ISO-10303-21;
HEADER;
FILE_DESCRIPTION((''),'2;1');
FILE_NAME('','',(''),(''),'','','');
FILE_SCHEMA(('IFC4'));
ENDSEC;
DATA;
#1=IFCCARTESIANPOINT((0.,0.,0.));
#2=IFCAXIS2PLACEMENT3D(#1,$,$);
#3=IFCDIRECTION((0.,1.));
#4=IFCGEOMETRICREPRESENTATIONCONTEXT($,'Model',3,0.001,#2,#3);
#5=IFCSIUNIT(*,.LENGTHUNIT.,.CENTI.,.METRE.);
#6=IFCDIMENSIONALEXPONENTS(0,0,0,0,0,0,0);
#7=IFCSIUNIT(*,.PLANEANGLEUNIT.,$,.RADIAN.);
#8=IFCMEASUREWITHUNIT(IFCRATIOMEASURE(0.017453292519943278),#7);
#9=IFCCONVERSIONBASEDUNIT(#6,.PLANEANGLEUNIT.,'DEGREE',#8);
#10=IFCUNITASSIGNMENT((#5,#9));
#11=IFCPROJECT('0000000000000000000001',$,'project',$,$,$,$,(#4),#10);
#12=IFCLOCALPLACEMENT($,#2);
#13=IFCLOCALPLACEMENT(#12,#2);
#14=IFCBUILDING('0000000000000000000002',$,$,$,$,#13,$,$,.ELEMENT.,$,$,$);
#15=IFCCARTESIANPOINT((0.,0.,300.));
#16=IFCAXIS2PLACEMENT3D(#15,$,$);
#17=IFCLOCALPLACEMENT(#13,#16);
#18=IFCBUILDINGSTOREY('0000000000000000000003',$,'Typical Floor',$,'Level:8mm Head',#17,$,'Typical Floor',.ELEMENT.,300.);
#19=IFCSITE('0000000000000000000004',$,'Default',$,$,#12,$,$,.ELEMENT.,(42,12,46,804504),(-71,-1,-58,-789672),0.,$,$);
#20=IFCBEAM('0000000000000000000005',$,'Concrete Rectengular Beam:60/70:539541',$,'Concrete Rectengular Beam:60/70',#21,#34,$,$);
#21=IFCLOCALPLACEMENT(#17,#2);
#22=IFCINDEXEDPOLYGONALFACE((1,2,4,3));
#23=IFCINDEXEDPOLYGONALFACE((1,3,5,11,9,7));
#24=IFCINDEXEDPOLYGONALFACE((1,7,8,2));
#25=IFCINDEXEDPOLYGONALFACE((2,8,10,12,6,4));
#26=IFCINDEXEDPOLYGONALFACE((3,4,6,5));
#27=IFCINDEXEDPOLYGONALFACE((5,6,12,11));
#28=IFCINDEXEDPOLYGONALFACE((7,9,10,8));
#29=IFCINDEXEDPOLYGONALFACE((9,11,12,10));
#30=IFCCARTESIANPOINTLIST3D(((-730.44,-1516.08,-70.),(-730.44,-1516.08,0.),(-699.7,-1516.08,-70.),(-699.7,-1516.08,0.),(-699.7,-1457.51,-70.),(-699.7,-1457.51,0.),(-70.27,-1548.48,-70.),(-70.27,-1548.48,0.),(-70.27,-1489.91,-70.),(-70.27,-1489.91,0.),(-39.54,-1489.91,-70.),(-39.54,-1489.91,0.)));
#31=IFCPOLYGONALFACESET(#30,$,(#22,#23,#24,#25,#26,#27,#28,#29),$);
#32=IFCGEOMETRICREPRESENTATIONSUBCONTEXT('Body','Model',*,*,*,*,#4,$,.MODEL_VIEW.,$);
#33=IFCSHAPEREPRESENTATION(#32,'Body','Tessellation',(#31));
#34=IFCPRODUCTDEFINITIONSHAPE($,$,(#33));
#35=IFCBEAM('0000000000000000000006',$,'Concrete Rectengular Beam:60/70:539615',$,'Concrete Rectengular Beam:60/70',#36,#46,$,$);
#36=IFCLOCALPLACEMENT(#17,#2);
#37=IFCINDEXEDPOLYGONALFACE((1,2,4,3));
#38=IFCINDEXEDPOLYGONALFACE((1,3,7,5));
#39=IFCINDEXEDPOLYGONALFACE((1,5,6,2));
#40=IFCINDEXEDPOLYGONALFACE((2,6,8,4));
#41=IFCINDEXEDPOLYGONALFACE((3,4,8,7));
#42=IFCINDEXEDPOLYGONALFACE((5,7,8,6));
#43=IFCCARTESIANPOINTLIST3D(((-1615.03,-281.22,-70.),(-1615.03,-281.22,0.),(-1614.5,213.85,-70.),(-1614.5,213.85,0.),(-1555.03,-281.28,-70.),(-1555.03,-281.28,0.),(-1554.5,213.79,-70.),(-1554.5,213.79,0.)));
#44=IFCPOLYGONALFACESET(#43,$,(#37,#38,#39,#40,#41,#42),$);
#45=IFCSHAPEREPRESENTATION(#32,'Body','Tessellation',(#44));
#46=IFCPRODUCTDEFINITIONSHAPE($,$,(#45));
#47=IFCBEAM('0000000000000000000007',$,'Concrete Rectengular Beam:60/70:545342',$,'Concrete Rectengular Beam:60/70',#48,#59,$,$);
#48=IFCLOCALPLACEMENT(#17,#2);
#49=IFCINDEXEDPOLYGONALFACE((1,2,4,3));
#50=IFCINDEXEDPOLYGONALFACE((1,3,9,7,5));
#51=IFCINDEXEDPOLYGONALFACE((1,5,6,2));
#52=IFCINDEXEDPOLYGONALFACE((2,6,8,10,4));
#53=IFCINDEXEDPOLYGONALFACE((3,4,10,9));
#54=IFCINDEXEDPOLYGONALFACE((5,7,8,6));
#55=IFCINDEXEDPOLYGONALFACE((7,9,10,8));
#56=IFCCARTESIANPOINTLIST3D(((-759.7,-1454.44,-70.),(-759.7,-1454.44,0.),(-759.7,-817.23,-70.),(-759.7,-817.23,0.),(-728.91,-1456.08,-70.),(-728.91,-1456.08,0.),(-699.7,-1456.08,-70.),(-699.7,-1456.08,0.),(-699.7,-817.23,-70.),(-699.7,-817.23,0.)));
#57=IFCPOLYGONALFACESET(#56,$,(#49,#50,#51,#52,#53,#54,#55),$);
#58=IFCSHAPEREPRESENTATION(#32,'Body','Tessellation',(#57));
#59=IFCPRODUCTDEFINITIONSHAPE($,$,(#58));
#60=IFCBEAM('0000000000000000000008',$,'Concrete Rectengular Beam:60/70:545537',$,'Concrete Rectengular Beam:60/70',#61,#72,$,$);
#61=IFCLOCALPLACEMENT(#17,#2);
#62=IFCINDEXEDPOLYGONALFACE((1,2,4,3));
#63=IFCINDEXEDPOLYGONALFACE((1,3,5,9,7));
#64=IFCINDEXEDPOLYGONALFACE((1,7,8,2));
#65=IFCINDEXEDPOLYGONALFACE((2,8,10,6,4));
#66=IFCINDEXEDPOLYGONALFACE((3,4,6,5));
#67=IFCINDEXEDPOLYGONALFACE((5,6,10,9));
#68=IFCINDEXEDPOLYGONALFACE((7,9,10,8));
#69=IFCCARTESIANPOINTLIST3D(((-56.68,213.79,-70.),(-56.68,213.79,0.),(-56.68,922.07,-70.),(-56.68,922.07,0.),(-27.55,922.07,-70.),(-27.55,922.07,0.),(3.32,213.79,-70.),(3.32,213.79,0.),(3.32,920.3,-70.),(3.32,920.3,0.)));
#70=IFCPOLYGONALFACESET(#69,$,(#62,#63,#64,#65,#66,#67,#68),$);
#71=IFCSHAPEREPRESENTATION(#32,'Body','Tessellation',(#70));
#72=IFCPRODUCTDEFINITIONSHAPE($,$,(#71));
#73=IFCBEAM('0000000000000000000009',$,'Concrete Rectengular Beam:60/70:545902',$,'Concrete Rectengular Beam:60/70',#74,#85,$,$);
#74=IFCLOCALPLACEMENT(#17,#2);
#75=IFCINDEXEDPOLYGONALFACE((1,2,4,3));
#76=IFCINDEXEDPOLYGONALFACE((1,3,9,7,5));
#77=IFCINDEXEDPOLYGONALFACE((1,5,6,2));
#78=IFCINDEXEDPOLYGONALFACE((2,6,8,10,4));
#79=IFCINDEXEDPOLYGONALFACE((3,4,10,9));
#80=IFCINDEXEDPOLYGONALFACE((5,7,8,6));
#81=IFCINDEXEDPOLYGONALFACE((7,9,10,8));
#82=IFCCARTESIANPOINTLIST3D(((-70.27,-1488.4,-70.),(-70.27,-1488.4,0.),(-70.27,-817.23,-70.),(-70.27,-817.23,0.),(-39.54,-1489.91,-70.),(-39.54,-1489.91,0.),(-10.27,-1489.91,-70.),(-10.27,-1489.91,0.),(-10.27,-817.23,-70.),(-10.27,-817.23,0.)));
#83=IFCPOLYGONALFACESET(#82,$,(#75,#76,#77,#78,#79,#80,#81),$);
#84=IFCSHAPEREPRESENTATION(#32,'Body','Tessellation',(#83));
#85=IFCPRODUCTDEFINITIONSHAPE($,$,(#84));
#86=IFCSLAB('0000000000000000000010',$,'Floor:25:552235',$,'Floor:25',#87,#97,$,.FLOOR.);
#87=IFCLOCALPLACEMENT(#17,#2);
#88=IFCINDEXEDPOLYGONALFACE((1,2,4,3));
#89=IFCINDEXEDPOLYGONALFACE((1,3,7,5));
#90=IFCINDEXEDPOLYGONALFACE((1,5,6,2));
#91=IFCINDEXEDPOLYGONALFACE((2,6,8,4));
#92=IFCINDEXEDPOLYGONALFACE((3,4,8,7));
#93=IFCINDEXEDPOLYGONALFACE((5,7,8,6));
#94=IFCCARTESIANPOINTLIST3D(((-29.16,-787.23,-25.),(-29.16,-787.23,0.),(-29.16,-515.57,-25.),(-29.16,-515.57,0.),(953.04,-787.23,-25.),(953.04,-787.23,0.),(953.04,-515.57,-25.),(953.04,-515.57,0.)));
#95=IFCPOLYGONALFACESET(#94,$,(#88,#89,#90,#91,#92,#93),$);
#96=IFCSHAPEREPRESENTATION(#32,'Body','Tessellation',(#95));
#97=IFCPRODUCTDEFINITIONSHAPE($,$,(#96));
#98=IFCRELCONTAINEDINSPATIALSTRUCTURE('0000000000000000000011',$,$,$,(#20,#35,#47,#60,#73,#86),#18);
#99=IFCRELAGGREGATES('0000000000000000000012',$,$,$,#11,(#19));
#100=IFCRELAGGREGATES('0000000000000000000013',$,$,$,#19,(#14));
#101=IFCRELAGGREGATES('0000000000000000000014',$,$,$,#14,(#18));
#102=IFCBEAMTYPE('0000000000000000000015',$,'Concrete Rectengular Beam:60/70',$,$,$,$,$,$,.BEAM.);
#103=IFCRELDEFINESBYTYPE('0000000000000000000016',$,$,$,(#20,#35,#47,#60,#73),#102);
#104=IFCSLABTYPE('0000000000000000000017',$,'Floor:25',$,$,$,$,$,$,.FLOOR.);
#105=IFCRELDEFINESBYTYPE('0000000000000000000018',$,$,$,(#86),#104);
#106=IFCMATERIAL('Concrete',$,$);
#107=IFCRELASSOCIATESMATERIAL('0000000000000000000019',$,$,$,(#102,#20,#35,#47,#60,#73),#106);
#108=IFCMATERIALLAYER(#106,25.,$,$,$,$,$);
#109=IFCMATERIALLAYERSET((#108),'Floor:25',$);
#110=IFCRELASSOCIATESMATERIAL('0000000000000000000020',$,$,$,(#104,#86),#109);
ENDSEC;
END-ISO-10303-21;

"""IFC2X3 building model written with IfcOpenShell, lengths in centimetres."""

from ifc_helpers import new_model, entity, si_unit, converted_unit, direction, frame, frame_2d, origin, place, context, subcontext, project, spatial, polyline, rectangle, extrude, clip, halfspace, bounded_halfspace, material, layer, layer_set, layer_usage, type_object, element, save


model = new_model("IFC2X3")

# Units and contexts
model_context = context("Model", 3, precision=0.001, world=origin(), true_north=direction((0.0, 1.0)))
body_context = subcontext(model_context, "Body", "Model", "MODEL_VIEW")
ifc_project = project(units=[si_unit("LENGTHUNIT", "METRE", prefix="CENTI"), converted_unit("PLANEANGLEUNIT", "DEGREE", entity("IfcRatioMeasure", 0.017453292519943278), si_unit("PLANEANGLEUNIT", "RADIAN"), dimensions=[0, 0, 0, 0, 0, 0, 0])], contexts=[model_context])

# Site, building, storey
site_placement = place(None, origin())
site = spatial("IfcSite", under=ifc_project, at=site_placement, Name="Default", CompositionType="ELEMENT", RefLatitude=(42, 12, 46, 804504), RefLongitude=(-71, -1, -58, -789672), RefElevation=0.0)
building_placement = place(site_placement, origin())
building = spatial("IfcBuilding", under=site, at=building_placement, CompositionType="ELEMENT")
storey_placement = place(building_placement, frame((0.0, 0.0, 300.0)))
storey = spatial("IfcBuildingStorey", under=building, at=storey_placement, Name="Typical Floor", ObjectType="Level:8mm Head", LongName="Typical Floor", CompositionType="ELEMENT", Elevation=300.0)

# Beams
ifc_material = material(Name="Concrete")
beam_type_1 = type_object("IfcBeamType", Name="Concrete Rectengular Beam:60/70", PredefinedType="BEAM", material=ifc_material)
beam_1_placement = place(storey_placement, frame((-40.27, -1519.91, 0.0), z_axis=(0.0, 0.0, 1.0), x_axis=(-0.998798, 0.049018, 0.0)))
element("IfcBeam", 1, at=beam_1_placement, inside=storey, type_object=beam_type_1, material=ifc_material, Name="Concrete Rectengular Beam:60/70:539541", ObjectType="Concrete Rectengular Beam:60/70", context=body_context, shape_type="SweptSolid", body=[
    clip(clip(clip(clip(extrude(rectangle(XDim=70.0, YDim=60.0, at=frame_2d((0.0, 0.0), x_axis=(1.0, 0.0))), frame((0.74, 0.0, -35.0), z_axis=(1.0, 0.0, 0.0), x_axis=(0.0, 0.0, -1.0)), (0.0, 0.0, 1.0), 688.79), bounded_halfspace(frame((658.83, 28.49, 0.0), z_axis=(0.998798, 0.049018, 0.0), x_axis=(0.0, 0.0, -1.0)), False, frame((0.74, 0.0, -35.0), z_axis=(1.0, 0.0, 0.0), x_axis=(0.0, 0.0, -1.0)), polyline([(35.0, 28.49), (-35.0, 28.49), (-35.0, -30.0), (-15.0, -30.0), (35.0, -30.0), (35.0, 28.49)]))), bounded_halfspace(frame((718.75, 31.43, 0.0), z_axis=(0.049018, -0.998798, 0.0), x_axis=(0.0, 0.0, -1.0)), False, frame((0.74, 0.0, -35.0), z_axis=(1.0, 0.0, 0.0), x_axis=(0.0, 0.0, -1.0)), polyline([(-35.0, 28.49), (35.0, 28.49), (35.0, 30.0), (-35.0, 30.0), (-35.0, 28.49)]))), bounded_halfspace(frame((-28.49, -31.43, 0.0), z_axis=(-0.049018, 0.998798, 0.0), x_axis=(0.0, 0.0, -1.0)), False, frame((0.74, 0.0, -35.0), z_axis=(1.0, 0.0, 0.0), x_axis=(0.0, 0.0, -1.0)), polyline([(-35.0, -28.49), (35.0, -28.49), (35.0, -30.0), (-35.0, -30.0), (-35.0, -28.49)]))), bounded_halfspace(frame((31.43, -28.49, 0.0), z_axis=(-0.998798, -0.049018, 0.0), x_axis=(0.0, 0.0, -1.0)), False, frame((0.74, 0.0, -35.0), z_axis=(1.0, 0.0, 0.0), x_axis=(0.0, 0.0, -1.0)), polyline([(35.0, -28.49), (-35.0, -28.49), (-35.0, 30.0), (35.0, 30.0), (35.0, -28.49)]))),
])
beam_2_placement = place(storey_placement, frame((-1585.07, -311.22, 0.0), z_axis=(0.0, 0.0, 1.0), x_axis=(0.001075, 0.999999, 0.0)))
element("IfcBeam", 2, at=beam_2_placement, inside=storey, type_object=beam_type_1, material=ifc_material, Name="Concrete Rectengular Beam:60/70:539615", ObjectType="Concrete Rectengular Beam:60/70", context=body_context, shape_type="SweptSolid", body=[
    extrude(rectangle(XDim=70.0, YDim=60.0, at=frame_2d((0.0, 0.0), x_axis=(1.0, 0.0))), frame((29.97, 0.0, -35.0), z_axis=(1.0, 0.0, 0.0), x_axis=(0.0, 0.0, -1.0)), (0.0, 0.0, 1.0), 495.07),
])
beam_3_placement = place(storey_placement, frame((-729.7, -1486.08, 0.0), z_axis=(0.0, 0.0, 1.0), x_axis=(0.0, 1.0, 0.0)))
element("IfcBeam", 3, at=beam_3_placement, inside=storey, type_object=beam_type_1, material=ifc_material, Name="Concrete Rectengular Beam:60/70:545342", ObjectType="Concrete Rectengular Beam:60/70", context=body_context, shape_type="SweptSolid", body=[
    clip(extrude(rectangle(XDim=70.0, YDim=60.0, at=frame_2d((0.0, 0.0), x_axis=(1.0, 0.0))), frame((30.0, 0.0, -35.0), z_axis=(1.0, 0.0, 0.0), x_axis=(0.0, 0.0, -1.0)), (0.0, 0.0, 1.0), 638.85), halfspace(frame((89.12, 1111.87, 0.0), z_axis=(-0.998591, 0.053061, 0.0), x_axis=(-0.053061, -0.998591, 0.0)), False)),
])
beam_4_placement = place(storey_placement, frame((-26.68, 952.07, 0.0), z_axis=(0.0, 0.0, 1.0), x_axis=(0.0, -1.0, 0.0)))
element("IfcBeam", 4, at=beam_4_placement, inside=storey, type_object=beam_type_1, material=ifc_material, Name="Concrete Rectengular Beam:60/70:545537", ObjectType="Concrete Rectengular Beam:60/70", context=body_context, shape_type="SweptSolid", body=[
    clip(extrude(rectangle(XDim=70.0, YDim=60.0, at=frame_2d((0.0, 0.0), x_axis=(1.0, 0.0))), frame((30.0, 0.0, -35.0), z_axis=(1.0, 0.0, 0.0), x_axis=(0.0, 0.0, -1.0)), (0.0, 0.0, 1.0), 708.29), halfspace(frame((66.75, 637.72, 0.0), z_axis=(-0.998348, 0.057459, 0.0), x_axis=(-0.057459, -0.998348, 0.0)), False)),
])
beam_5_placement = place(storey_placement, frame((-40.27, -1519.91, 0.0), z_axis=(0.0, 0.0, 1.0), x_axis=(0.0, 1.0, 0.0)))
element("IfcBeam", 5, at=beam_5_placement, inside=storey, type_object=beam_type_1, material=ifc_material, Name="Concrete Rectengular Beam:60/70:545902", ObjectType="Concrete Rectengular Beam:60/70", context=body_context, shape_type="SweptSolid", body=[
    clip(extrude(rectangle(XDim=70.0, YDim=60.0, at=frame_2d((0.0, 0.0), x_axis=(1.0, 0.0))), frame((30.0, 0.0, -35.0), z_axis=(1.0, 0.0, 0.0), x_axis=(0.0, 0.0, -1.0)), (0.0, 0.0, 1.0), 672.68), halfspace(frame((62.2, 655.29, 0.0), z_axis=(-0.998798, 0.049018, 0.0), x_axis=(-0.049018, -0.998798, 0.0)), False)),
])

# Slab
ifc_layer_1 = layer(ifc_material, 25.0)
ifc_layer_set_1 = layer_set([ifc_layer_1], Name="Floor:25")
ifc_layer_usage_1 = layer_usage(ifc_layer_set_1, "AXIS3", "POSITIVE", 0.0)
slab_type_1 = type_object("IfcSlabType", Name="Floor:25", PredefinedType="FLOOR", material=ifc_layer_set_1)
slab_1_placement = place(storey_placement, origin())
element("IfcSlab", 6, at=slab_1_placement, inside=storey, type_object=slab_type_1, material=ifc_layer_usage_1, Name="Floor:25:552235", ObjectType="Floor:25", PredefinedType="FLOOR", context=body_context, shape_type="SweptSolid", body=[
    extrude(rectangle(XDim=271.66, YDim=982.2, at=frame_2d((0.0, 0.0), x_axis=(1.0, 0.0))), frame((461.94, -651.4, 0.0), z_axis=(0.0, 0.0, -1.0), x_axis=(0.0, 1.0, 0.0)), (0.0, 0.0, 1.0), 25.0),
])

save(model, "model.ifc")
